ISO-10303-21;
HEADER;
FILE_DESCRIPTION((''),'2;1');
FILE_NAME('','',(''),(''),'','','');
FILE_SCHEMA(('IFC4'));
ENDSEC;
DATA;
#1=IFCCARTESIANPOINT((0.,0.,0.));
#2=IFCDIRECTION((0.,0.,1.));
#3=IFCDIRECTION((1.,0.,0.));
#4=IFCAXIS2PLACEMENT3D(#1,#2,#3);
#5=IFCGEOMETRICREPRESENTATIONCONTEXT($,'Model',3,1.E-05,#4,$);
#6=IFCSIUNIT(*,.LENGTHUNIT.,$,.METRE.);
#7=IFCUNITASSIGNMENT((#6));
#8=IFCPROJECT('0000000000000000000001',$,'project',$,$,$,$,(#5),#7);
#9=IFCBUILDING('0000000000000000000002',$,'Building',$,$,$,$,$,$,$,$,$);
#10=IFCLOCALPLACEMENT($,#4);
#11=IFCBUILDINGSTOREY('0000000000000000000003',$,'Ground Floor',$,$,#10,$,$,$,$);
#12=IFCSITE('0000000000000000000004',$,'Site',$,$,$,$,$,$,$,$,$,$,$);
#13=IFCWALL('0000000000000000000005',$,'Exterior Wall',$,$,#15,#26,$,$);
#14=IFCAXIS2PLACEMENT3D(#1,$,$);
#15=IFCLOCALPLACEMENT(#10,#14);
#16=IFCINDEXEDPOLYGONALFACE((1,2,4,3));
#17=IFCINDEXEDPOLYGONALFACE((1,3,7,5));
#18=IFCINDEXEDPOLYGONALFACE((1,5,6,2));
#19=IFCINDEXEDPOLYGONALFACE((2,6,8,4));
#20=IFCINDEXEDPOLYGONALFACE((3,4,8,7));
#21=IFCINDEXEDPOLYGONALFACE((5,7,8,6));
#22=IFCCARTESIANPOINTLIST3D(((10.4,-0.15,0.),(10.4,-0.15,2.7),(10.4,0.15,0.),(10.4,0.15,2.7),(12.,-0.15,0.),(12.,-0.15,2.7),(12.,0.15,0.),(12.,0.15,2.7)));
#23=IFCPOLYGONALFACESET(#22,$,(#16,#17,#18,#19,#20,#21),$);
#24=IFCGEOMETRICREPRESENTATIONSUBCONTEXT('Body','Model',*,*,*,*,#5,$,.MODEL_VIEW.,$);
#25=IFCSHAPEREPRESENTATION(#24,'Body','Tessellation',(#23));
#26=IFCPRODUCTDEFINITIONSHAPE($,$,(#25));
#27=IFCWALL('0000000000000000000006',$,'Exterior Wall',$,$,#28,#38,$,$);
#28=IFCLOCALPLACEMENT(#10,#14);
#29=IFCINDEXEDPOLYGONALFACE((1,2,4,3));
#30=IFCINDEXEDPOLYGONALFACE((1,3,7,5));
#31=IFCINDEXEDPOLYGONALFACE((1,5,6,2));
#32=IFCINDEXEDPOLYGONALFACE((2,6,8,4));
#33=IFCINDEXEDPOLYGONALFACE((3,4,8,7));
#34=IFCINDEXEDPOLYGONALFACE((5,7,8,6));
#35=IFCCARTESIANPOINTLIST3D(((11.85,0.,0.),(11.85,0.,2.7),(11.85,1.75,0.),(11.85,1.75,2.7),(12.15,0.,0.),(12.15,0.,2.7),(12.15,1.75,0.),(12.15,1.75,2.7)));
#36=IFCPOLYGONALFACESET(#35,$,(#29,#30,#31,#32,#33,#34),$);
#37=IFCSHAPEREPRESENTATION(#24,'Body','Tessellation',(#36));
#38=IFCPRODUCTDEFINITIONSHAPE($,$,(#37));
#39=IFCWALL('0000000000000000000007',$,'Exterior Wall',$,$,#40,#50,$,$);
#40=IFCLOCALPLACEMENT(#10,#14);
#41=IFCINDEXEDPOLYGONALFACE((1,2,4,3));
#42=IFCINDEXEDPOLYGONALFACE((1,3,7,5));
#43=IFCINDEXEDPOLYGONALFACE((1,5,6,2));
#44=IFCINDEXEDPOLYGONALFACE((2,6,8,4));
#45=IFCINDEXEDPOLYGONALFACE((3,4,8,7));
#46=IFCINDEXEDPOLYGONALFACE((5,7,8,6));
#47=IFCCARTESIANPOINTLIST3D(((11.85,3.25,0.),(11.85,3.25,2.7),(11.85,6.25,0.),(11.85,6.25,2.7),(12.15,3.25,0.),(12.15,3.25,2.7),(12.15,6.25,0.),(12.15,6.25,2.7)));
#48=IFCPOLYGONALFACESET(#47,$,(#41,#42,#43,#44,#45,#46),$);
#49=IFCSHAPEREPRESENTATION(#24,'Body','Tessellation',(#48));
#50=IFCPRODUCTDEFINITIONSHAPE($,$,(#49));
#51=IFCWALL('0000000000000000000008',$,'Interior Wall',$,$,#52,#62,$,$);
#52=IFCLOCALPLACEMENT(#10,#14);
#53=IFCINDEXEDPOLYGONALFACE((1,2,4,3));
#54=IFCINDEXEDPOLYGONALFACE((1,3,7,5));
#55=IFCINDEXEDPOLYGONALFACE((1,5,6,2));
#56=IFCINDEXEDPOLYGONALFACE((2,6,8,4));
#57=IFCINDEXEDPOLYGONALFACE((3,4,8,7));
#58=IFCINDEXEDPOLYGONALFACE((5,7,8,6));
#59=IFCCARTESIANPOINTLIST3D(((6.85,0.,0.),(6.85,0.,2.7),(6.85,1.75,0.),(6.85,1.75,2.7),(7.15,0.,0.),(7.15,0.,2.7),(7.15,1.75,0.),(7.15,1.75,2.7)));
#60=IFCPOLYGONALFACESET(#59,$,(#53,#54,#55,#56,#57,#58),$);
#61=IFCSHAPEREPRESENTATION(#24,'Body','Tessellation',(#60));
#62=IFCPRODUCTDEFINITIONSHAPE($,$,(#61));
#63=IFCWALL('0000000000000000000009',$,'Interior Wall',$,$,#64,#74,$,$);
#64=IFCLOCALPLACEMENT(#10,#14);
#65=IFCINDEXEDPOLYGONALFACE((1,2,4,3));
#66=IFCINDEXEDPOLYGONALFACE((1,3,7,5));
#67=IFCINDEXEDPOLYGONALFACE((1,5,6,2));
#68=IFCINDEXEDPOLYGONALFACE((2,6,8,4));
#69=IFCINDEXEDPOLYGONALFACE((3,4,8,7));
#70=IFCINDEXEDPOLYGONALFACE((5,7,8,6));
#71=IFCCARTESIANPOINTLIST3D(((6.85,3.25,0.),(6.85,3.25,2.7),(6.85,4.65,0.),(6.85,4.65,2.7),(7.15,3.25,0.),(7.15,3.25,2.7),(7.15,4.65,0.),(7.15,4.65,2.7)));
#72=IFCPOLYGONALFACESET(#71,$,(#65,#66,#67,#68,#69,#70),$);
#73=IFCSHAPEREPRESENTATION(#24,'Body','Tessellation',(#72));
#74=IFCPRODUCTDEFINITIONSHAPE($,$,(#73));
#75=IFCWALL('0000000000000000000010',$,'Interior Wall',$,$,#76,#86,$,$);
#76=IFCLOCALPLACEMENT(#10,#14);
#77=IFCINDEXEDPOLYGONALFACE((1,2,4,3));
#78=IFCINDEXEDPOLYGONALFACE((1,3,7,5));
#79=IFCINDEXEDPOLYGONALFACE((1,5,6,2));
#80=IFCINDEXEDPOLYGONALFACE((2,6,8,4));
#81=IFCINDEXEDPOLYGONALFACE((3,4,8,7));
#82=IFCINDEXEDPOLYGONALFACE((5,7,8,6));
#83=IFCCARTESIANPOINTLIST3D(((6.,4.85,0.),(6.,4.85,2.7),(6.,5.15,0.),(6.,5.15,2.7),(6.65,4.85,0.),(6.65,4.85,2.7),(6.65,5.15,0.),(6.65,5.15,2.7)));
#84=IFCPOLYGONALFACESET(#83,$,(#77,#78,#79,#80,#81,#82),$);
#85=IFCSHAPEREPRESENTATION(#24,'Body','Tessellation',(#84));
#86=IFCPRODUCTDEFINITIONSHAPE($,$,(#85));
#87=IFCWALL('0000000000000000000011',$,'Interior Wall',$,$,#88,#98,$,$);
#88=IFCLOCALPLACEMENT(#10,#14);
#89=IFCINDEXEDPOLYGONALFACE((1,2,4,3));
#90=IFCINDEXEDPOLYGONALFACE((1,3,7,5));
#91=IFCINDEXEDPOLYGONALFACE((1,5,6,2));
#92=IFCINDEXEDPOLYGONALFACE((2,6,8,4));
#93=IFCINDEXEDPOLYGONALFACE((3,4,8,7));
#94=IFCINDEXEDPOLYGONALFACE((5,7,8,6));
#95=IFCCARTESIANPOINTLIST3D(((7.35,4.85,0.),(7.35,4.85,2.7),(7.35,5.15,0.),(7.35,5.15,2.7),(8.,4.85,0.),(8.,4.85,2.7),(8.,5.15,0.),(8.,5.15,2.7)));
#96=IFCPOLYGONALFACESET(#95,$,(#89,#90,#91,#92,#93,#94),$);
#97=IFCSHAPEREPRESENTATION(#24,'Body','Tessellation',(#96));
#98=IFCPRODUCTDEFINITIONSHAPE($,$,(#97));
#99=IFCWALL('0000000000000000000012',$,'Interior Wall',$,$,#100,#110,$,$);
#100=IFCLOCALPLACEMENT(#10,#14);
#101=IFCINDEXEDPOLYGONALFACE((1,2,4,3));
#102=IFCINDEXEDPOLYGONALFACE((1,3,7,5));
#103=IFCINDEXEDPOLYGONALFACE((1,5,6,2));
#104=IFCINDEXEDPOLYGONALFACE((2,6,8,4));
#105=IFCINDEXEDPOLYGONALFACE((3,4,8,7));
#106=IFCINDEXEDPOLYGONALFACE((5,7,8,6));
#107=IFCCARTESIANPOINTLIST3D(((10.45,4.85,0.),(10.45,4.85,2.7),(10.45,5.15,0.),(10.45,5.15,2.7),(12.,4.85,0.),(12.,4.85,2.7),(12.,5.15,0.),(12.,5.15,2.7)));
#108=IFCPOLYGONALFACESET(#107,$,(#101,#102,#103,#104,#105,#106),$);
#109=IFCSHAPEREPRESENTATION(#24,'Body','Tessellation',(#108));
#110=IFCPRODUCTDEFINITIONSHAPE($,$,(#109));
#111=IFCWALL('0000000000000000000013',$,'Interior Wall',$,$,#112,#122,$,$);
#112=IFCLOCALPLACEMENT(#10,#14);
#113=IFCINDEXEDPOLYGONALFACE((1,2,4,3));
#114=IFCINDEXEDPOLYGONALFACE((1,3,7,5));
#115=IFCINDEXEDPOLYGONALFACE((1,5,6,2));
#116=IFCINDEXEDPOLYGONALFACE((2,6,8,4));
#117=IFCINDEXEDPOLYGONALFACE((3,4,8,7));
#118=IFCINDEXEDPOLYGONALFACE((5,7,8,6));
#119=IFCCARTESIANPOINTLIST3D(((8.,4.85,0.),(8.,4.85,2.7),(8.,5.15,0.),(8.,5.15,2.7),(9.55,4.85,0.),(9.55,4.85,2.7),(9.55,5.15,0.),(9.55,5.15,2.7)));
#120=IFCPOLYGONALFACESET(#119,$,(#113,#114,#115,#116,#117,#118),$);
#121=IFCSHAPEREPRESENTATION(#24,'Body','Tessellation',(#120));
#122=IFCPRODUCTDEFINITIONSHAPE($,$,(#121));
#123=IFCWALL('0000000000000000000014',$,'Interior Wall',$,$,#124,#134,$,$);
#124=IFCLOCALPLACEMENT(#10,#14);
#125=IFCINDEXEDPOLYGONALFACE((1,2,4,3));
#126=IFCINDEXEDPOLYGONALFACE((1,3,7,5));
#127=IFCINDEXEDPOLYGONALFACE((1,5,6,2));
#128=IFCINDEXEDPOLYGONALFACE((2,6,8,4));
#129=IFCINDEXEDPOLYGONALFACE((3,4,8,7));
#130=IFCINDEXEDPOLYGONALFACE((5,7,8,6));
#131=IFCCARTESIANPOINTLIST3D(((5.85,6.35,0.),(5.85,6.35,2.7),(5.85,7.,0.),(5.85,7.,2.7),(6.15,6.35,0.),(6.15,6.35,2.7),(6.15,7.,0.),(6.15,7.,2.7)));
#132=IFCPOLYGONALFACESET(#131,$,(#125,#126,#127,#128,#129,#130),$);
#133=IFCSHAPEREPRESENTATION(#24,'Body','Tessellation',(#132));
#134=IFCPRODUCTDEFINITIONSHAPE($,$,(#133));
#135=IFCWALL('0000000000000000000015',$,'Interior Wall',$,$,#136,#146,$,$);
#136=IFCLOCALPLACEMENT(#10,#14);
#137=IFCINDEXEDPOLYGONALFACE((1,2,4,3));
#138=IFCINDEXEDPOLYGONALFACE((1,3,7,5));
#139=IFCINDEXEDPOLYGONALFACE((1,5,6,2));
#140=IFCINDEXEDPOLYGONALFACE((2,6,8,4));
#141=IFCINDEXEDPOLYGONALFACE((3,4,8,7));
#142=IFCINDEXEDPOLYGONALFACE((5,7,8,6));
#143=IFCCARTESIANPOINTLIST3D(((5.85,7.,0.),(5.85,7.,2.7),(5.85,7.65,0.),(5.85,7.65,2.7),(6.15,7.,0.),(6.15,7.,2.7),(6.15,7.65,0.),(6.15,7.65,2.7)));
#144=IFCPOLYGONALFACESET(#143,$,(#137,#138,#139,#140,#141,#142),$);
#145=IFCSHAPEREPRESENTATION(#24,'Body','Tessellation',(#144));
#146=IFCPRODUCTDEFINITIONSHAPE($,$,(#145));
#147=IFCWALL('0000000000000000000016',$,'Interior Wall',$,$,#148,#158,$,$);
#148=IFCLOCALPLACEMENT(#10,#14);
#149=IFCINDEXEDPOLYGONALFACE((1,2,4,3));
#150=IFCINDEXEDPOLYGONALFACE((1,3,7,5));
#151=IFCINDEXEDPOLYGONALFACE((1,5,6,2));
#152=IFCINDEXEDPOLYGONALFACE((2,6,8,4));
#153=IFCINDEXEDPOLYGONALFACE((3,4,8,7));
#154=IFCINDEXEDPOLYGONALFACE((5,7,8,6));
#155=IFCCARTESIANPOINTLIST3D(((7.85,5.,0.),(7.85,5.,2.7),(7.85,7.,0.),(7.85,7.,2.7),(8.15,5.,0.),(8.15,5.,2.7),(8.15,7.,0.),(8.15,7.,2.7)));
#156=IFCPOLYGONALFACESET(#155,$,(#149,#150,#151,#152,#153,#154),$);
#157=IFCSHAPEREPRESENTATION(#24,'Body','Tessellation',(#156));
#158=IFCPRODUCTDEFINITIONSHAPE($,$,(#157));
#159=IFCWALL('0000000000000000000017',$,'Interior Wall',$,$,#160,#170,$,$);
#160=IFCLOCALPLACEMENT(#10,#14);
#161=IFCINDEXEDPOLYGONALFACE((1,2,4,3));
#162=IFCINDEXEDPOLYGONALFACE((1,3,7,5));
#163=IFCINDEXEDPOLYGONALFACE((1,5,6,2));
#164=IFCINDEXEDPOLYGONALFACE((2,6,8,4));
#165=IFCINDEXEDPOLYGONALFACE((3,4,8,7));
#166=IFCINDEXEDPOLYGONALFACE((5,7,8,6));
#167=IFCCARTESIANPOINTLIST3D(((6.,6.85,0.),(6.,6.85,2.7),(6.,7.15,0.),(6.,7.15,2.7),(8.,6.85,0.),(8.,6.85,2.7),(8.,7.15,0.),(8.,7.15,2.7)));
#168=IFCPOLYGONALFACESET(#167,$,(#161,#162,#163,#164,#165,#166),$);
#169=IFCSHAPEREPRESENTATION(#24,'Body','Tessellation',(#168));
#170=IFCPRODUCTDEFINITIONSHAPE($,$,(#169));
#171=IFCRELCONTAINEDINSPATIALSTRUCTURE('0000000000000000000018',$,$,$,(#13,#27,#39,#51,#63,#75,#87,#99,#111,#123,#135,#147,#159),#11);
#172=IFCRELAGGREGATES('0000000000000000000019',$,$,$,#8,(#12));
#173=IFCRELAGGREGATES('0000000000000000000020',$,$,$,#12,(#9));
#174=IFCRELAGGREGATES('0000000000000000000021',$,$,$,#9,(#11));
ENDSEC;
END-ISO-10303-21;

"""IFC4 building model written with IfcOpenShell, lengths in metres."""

from ifc_helpers import new_model, si_unit, frame, origin_with_axes, place, context, subcontext, project, spatial, indexed_curve, outline, extrude, element, save


model = new_model("IFC4")

# Units and contexts
model_context = context("Model", 3, precision=1e-05, world=origin_with_axes())
body_context = subcontext(model_context, "Body", "Model", "MODEL_VIEW")
ifc_project = project(units=[si_unit("LENGTHUNIT", "METRE")], contexts=[model_context])

# Site, building, storey
site = spatial("IfcSite", under=ifc_project, Name="Site")
building = spatial("IfcBuilding", under=site, Name="Building")
storey_placement = place(None, origin_with_axes())
storey = spatial("IfcBuildingStorey", under=building, at=storey_placement, Name="Ground Floor")

# Walls
wall_1_placement = place(storey_placement, frame((10.4, 0.0, 0.0), z_axis=(0.0, 0.0, 1.0), x_axis=(1.0, 0.0, 0.0)))
element("IfcWall", 1, at=wall_1_placement, inside=storey, Name="Exterior Wall", context=body_context, shape_type="SweptSolid", body=[
    extrude(outline(indexed_curve([(0.0, 0.0), (0.0, 0.3), (1.6, 0.3), (1.6, 0.0), (0.0, 0.0)], self_intersect=False)), frame((0.0, -0.15, 0.0), z_axis=(0.0, 0.0, 1.0), x_axis=(1.0, 0.0, 0.0)), (0.0, 0.0, 1.0), 2.7),
])
wall_2_placement = place(storey_placement, frame((12.0, 0.0, 0.0), z_axis=(0.0, 0.0, 1.0), x_axis=(0.0, 1.0, 0.0)))
element("IfcWall", 2, at=wall_2_placement, inside=storey, Name="Exterior Wall", context=body_context, shape_type="SweptSolid", body=[
    extrude(outline(indexed_curve([(0.0, 0.0), (0.0, 0.3), (1.75, 0.3), (1.75, 0.0), (0.0, 0.0)], self_intersect=False)), frame((0.0, -0.15, 0.0), z_axis=(0.0, 0.0, 1.0), x_axis=(1.0, 0.0, 0.0)), (0.0, 0.0, 1.0), 2.7),
])
wall_3_placement = place(storey_placement, frame((12.0, 3.25, 0.0), z_axis=(0.0, 0.0, 1.0), x_axis=(0.0, 1.0, 0.0)))
element("IfcWall", 3, at=wall_3_placement, inside=storey, Name="Exterior Wall", context=body_context, shape_type="SweptSolid", body=[
    extrude(outline(indexed_curve([(0.0, 0.0), (0.0, 0.3), (3.0, 0.3), (3.0, 0.0), (0.0, 0.0)], self_intersect=False)), frame((0.0, -0.15, 0.0), z_axis=(0.0, 0.0, 1.0), x_axis=(1.0, 0.0, 0.0)), (0.0, 0.0, 1.0), 2.7),
])
wall_4_placement = place(storey_placement, frame((7.0, 0.0, 0.0), z_axis=(0.0, 0.0, 1.0), x_axis=(0.0, 1.0, 0.0)))
element("IfcWall", 4, at=wall_4_placement, inside=storey, Name="Interior Wall", context=body_context, shape_type="SweptSolid", body=[
    extrude(outline(indexed_curve([(0.0, 0.0), (0.0, 0.3), (1.75, 0.3), (1.75, 0.0), (0.0, 0.0)], self_intersect=False)), frame((0.0, -0.15, 0.0), z_axis=(0.0, 0.0, 1.0), x_axis=(1.0, 0.0, 0.0)), (0.0, 0.0, 1.0), 2.7),
])
wall_5_placement = place(storey_placement, frame((7.0, 3.25, 0.0), z_axis=(0.0, 0.0, 1.0), x_axis=(0.0, 1.0, 0.0)))
element("IfcWall", 5, at=wall_5_placement, inside=storey, Name="Interior Wall", context=body_context, shape_type="SweptSolid", body=[
    extrude(outline(indexed_curve([(0.0, 0.0), (0.0, 0.3), (1.4, 0.3), (1.4, 0.0), (0.0, 0.0)], self_intersect=False)), frame((0.0, -0.15, 0.0), z_axis=(0.0, 0.0, 1.0), x_axis=(1.0, 0.0, 0.0)), (0.0, 0.0, 1.0), 2.7),
])
for number, where, z_axis, x_axis, name in (
    (6, (6.65, 5.0, 0.0), (0.0, 0.0, 1.0), (-1.0, 0.0, 0.0), "Interior Wall"),
    (7, (8.0, 5.0, 0.0), (0.0, 0.0, 1.0), (-1.0, 0.0, 0.0), "Interior Wall"),
):
    element("IfcWall", number, at=place(storey_placement, frame(where, z_axis=z_axis, x_axis=x_axis)), inside=storey, Name=name, context=body_context, shape_type="SweptSolid", body=[
        extrude(outline(indexed_curve([(0.0, 0.0), (0.0, 0.3), (0.65, 0.3), (0.65, 0.0), (0.0, 0.0)], self_intersect=False)), frame((0.0, -0.15, 0.0), z_axis=(0.0, 0.0, 1.0), x_axis=(1.0, 0.0, 0.0)), (0.0, 0.0, 1.0), 2.7),
    ])
for number, where, z_axis, x_axis, name in (
    (8, (12.0, 5.0, 0.0), (0.0, 0.0, 1.0), (-1.0, 0.0, 0.0), "Interior Wall"),
    (9, (9.55, 5.0, 0.0), (0.0, 0.0, 1.0), (-1.0, 0.0, 0.0), "Interior Wall"),
):
    element("IfcWall", number, at=place(storey_placement, frame(where, z_axis=z_axis, x_axis=x_axis)), inside=storey, Name=name, context=body_context, shape_type="SweptSolid", body=[
        extrude(outline(indexed_curve([(0.0, 0.0), (0.0, 0.3), (1.55, 0.3), (1.55, 0.0), (0.0, 0.0)], self_intersect=False)), frame((0.0, -0.15, 0.0), z_axis=(0.0, 0.0, 1.0), x_axis=(1.0, 0.0, 0.0)), (0.0, 0.0, 1.0), 2.7),
    ])
for number, where, z_axis, x_axis, name in (
    (10, (6.0, 6.35, 0.0), (0.0, 0.0, 1.0), (0.0, 1.0, 0.0), "Interior Wall"),
    (11, (6.0, 7.0, 0.0), (0.0, 0.0, 1.0), (0.0, 1.0, 0.0), "Interior Wall"),
):
    element("IfcWall", number, at=place(storey_placement, frame(where, z_axis=z_axis, x_axis=x_axis)), inside=storey, Name=name, context=body_context, shape_type="SweptSolid", body=[
        extrude(outline(indexed_curve([(0.0, 0.0), (0.0, 0.3), (0.65, 0.3), (0.65, 0.0), (0.0, 0.0)], self_intersect=False)), frame((0.0, -0.15, 0.0), z_axis=(0.0, 0.0, 1.0), x_axis=(1.0, 0.0, 0.0)), (0.0, 0.0, 1.0), 2.7),
    ])
for number, where, z_axis, x_axis, name in (
    (12, (8.0, 5.0, 0.0), (0.0, 0.0, 1.0), (0.0, 1.0, 0.0), "Interior Wall"),
    (13, (8.0, 7.0, 0.0), (0.0, 0.0, 1.0), (-1.0, 0.0, 0.0), "Interior Wall"),
):
    element("IfcWall", number, at=place(storey_placement, frame(where, z_axis=z_axis, x_axis=x_axis)), inside=storey, Name=name, context=body_context, shape_type="SweptSolid", body=[
        extrude(outline(indexed_curve([(0.0, 0.0), (0.0, 0.3), (2.0, 0.3), (2.0, 0.0), (0.0, 0.0)], self_intersect=False)), frame((0.0, -0.15, 0.0), z_axis=(0.0, 0.0, 1.0), x_axis=(1.0, 0.0, 0.0)), (0.0, 0.0, 1.0), 2.7),
    ])

save(model, "model.ifc")
